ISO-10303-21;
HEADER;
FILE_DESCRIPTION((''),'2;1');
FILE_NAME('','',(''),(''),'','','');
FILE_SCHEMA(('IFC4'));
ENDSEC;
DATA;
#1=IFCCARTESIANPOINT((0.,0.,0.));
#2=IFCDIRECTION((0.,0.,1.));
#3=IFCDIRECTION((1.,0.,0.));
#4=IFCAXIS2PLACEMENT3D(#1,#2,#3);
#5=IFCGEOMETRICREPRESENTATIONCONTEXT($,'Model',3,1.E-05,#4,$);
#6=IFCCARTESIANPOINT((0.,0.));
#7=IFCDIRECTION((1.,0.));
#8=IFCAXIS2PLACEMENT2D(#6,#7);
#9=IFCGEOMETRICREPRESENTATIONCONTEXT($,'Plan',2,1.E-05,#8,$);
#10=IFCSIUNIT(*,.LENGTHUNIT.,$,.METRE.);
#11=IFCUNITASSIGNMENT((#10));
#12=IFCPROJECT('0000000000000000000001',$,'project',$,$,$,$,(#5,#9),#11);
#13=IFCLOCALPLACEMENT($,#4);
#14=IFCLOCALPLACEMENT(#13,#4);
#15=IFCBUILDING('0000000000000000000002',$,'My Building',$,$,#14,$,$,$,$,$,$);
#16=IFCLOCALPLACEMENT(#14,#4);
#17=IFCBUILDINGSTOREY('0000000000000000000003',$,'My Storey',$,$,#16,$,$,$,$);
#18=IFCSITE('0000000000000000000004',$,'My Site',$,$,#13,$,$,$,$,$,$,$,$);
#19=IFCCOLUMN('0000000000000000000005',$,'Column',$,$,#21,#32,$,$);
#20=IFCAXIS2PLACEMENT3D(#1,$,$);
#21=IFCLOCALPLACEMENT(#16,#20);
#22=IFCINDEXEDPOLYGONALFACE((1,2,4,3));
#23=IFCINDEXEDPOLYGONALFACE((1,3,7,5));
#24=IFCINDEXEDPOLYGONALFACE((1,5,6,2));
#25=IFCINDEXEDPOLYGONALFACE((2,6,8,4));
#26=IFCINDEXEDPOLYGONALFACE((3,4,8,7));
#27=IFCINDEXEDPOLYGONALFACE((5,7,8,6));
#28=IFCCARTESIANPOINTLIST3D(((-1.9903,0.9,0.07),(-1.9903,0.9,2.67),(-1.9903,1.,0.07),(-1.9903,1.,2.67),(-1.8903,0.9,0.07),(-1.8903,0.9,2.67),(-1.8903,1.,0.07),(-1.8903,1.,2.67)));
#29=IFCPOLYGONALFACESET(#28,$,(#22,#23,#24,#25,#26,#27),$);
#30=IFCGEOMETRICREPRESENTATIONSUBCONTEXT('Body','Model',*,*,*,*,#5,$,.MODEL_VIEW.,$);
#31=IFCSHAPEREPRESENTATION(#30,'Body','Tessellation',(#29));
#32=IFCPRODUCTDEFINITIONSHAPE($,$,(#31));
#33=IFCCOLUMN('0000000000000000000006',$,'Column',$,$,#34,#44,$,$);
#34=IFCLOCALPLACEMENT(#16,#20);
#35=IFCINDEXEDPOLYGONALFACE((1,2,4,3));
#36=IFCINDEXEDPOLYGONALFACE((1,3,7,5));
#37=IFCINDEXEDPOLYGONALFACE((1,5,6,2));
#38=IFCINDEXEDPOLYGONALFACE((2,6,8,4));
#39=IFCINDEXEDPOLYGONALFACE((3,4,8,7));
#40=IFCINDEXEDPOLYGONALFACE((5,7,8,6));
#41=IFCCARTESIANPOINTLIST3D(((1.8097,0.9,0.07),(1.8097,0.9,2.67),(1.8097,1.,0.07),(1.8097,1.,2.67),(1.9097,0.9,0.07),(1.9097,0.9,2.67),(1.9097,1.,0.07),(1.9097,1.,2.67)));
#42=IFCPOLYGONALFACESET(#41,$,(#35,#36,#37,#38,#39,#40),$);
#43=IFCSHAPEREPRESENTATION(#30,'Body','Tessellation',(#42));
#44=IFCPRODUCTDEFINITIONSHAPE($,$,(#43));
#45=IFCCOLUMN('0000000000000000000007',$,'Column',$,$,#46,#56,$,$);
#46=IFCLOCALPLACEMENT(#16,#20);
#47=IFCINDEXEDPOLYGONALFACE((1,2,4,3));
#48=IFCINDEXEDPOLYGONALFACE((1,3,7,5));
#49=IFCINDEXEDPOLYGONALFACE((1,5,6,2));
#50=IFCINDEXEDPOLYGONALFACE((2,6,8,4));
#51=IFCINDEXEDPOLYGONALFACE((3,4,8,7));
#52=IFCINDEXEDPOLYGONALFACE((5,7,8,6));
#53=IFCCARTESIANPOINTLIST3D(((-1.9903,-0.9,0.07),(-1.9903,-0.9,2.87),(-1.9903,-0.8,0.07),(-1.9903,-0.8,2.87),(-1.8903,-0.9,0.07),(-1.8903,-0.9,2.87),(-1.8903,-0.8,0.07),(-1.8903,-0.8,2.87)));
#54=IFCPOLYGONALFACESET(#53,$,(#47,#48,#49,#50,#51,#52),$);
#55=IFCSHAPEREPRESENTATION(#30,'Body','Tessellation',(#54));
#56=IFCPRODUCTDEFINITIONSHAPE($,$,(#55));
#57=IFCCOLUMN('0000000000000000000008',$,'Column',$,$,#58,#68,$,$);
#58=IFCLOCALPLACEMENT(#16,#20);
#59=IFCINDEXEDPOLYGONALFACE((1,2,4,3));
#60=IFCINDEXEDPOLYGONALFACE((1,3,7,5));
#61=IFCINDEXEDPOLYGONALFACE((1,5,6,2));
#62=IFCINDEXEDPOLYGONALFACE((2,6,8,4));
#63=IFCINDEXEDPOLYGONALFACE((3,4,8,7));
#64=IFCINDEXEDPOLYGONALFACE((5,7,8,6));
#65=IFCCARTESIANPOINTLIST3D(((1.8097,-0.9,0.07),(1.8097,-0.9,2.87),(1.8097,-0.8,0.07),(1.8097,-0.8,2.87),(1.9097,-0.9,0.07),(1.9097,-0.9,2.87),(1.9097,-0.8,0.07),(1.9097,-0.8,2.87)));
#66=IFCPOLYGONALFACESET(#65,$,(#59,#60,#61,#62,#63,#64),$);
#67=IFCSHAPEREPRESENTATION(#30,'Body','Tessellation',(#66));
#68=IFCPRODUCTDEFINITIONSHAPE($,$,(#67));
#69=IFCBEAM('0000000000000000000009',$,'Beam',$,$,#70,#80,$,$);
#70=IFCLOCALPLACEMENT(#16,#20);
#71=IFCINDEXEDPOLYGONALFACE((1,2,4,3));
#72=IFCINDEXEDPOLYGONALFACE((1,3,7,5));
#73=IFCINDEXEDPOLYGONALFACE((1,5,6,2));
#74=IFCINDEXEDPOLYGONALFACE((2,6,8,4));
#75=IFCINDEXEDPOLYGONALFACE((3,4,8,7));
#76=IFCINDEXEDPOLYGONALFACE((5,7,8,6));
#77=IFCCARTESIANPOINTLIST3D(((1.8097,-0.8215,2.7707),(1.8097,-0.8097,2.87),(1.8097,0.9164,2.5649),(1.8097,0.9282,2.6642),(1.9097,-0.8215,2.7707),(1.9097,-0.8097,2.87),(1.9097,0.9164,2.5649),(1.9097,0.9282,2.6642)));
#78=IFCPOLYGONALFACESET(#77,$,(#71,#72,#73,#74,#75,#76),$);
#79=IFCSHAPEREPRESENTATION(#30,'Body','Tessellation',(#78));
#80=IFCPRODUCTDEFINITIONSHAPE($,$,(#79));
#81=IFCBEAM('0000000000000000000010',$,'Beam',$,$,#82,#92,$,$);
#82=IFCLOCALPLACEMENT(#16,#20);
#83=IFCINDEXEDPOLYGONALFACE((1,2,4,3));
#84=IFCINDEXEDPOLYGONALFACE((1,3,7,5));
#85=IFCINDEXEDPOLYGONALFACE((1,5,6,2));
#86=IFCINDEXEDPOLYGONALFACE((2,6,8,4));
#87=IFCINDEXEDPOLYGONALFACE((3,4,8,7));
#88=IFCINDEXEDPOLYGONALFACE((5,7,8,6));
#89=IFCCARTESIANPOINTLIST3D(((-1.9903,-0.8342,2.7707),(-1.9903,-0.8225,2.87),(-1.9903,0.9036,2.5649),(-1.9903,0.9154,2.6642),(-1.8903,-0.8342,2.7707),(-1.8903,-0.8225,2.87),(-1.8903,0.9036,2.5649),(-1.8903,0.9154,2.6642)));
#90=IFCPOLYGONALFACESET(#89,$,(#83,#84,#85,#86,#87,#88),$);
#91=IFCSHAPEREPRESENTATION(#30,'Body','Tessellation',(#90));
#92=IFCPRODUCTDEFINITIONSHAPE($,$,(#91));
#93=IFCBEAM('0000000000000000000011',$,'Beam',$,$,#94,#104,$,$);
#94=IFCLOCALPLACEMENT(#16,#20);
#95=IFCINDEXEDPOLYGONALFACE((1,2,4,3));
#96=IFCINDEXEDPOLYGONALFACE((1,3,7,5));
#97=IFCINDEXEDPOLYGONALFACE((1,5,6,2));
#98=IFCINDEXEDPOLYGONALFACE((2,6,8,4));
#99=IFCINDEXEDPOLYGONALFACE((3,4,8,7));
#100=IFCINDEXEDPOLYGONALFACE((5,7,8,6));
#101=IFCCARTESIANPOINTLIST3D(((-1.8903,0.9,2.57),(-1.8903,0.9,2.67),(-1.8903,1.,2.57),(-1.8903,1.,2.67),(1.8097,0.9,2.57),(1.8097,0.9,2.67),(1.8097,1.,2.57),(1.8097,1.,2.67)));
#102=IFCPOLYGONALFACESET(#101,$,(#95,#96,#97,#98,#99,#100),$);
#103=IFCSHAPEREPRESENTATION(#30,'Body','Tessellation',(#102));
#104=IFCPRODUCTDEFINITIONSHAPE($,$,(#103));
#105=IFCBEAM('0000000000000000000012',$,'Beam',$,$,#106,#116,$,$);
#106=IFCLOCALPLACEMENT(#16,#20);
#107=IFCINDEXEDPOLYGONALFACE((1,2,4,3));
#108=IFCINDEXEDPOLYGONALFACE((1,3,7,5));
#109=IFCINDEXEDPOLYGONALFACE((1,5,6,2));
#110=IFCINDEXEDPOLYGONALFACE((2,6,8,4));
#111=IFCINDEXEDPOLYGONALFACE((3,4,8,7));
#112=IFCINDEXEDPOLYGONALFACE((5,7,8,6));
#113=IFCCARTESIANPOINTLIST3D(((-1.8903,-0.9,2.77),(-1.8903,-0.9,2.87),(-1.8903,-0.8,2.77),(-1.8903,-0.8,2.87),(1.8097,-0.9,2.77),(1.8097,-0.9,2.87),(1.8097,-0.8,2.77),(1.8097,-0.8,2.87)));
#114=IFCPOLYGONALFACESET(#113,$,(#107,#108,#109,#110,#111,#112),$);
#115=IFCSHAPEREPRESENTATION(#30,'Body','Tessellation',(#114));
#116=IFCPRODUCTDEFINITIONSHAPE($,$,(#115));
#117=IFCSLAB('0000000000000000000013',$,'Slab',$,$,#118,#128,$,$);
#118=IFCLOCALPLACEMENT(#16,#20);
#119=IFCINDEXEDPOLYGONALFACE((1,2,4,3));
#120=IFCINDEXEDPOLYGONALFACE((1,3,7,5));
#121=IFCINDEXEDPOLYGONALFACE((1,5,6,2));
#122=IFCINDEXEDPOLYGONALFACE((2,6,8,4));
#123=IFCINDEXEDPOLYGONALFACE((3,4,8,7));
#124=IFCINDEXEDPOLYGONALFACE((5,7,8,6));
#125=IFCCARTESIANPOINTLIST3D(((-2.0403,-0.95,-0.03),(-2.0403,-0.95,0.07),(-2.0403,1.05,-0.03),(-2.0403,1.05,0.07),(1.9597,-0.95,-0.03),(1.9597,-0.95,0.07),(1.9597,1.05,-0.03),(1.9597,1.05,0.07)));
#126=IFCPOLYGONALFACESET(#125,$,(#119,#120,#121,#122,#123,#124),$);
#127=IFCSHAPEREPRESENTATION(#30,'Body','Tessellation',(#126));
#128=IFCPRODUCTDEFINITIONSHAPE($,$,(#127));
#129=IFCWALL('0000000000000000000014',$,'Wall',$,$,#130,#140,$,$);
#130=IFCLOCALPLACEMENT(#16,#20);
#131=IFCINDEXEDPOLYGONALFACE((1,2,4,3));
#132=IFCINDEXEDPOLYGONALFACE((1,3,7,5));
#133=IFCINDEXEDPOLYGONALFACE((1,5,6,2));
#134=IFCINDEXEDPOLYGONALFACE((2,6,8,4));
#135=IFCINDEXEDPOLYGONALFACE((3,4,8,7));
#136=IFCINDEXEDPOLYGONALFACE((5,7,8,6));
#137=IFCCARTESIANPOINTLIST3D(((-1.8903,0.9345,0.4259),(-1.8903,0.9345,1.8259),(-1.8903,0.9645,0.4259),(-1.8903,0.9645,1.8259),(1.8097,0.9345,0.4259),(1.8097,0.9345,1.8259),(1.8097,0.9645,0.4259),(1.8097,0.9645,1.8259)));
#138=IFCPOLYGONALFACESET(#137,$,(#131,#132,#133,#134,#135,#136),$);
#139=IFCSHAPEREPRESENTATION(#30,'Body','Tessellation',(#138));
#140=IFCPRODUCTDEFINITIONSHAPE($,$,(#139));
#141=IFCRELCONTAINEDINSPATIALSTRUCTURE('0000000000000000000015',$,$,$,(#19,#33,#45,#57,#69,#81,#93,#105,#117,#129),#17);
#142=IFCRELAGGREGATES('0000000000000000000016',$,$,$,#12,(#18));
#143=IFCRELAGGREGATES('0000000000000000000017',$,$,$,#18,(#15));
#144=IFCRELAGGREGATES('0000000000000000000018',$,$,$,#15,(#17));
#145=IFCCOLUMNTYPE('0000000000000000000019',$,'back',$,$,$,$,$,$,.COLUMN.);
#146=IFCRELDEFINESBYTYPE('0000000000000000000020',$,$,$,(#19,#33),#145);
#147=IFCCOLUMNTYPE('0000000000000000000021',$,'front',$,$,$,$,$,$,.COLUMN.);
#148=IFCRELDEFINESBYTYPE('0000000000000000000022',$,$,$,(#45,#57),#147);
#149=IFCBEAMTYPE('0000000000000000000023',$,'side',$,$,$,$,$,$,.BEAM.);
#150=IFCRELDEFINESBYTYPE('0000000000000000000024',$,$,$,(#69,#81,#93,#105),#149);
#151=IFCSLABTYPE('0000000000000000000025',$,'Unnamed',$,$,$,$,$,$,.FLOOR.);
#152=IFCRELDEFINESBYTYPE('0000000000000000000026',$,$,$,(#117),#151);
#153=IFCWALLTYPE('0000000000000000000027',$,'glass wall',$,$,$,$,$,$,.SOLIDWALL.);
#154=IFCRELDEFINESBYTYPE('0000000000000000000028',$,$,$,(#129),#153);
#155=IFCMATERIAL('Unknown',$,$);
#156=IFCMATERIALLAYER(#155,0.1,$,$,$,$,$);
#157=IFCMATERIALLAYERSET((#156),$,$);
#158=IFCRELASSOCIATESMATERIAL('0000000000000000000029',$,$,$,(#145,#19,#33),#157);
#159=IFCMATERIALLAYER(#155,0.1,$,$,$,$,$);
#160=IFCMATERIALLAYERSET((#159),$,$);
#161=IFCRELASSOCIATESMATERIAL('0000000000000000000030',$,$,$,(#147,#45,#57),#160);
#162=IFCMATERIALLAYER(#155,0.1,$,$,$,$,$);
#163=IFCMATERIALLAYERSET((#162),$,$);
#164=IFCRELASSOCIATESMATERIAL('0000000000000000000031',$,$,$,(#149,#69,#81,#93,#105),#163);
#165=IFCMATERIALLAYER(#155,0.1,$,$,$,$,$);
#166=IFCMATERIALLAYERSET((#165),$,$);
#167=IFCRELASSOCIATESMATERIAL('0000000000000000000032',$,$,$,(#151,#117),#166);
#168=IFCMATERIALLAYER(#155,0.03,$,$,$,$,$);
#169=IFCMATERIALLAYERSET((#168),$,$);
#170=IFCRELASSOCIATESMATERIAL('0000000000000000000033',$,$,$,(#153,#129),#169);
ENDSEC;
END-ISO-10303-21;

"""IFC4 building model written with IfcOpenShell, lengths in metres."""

from ifc_helpers import new_model, si_unit, frame, origin_with_axes, origin_2d_with_axis, place, context, subcontext, project, spatial, line, indexed_curve, outline, extrude, material, layer, layer_set, layer_usage, type_object, element, save


model = new_model("IFC4")

# Units and contexts
model_context = context("Model", 3, precision=1e-05, world=origin_with_axes())
plan_context = context("Plan", 2, precision=1e-05, world=origin_2d_with_axis())
body_context = subcontext(model_context, "Body", "Model", "MODEL_VIEW")
ifc_project = project(units=[si_unit("LENGTHUNIT", "METRE")], contexts=[model_context, plan_context])

# Site, building, storey
site_placement = place(None, origin_with_axes())
site = spatial("IfcSite", under=ifc_project, at=site_placement, Name="My Site")
building_placement = place(site_placement, origin_with_axes())
building = spatial("IfcBuilding", under=site, at=building_placement, Name="My Building")
storey_placement = place(building_placement, origin_with_axes())
storey = spatial("IfcBuildingStorey", under=building, at=storey_placement, Name="My Storey")

# Columns
ifc_material = material(Name="Unknown")
ifc_layer_1 = layer(ifc_material, 0.1)
ifc_layer_set_1 = layer_set([ifc_layer_1])
ifc_layer_usage_1 = layer_usage(ifc_layer_set_1, "AXIS2", "POSITIVE", 0.0)
column_type_1 = type_object("IfcColumnType", Name="back", PredefinedType="COLUMN", material=ifc_layer_set_1)
column_1_placement = place(storey_placement, frame((-1.9903, 1.0, 0.07), z_axis=(0.0, 0.0, 1.0), x_axis=(0.0, -1.0, 0.0)))
element("IfcColumn", 1, at=column_1_placement, inside=storey, type_object=column_type_1, material=ifc_layer_usage_1, Name="Column", context=body_context, shape_type="SweptSolid", body=[
    extrude(outline(indexed_curve([(0.0, 0.0), (0.0, 0.1), (0.1, 0.1), (0.1, 0.0)], segments=[line(1, 2, 3, 4, 1)])), origin_with_axes(), (0.0, 0.0, 1.0), 2.6),
])
ifc_layer_usage_2 = layer_usage(ifc_layer_set_1, "AXIS2", "POSITIVE", 0.0)
column_2_placement = place(storey_placement, frame((1.8097, 0.9, 0.07), z_axis=(0.0, 0.0, 1.0), x_axis=(1.0, 0.0, 0.0)))
element("IfcColumn", 2, at=column_2_placement, inside=storey, type_object=column_type_1, material=ifc_layer_usage_2, Name="Column", context=body_context, shape_type="SweptSolid", body=[
    extrude(outline(indexed_curve([(0.0, 0.0), (0.0, 0.1), (0.1, 0.1), (0.1, 0.0)], segments=[line(1, 2, 3, 4, 1)])), origin_with_axes(), (0.0, 0.0, 1.0), 2.6),
])
ifc_layer_2 = layer(ifc_material, 0.1)
ifc_layer_set_2 = layer_set([ifc_layer_2])
ifc_layer_usage_3 = layer_usage(ifc_layer_set_2, "AXIS2", "POSITIVE", 0.0)
column_type_2 = type_object("IfcColumnType", Name="front", PredefinedType="COLUMN", material=ifc_layer_set_2)
column_3_placement = place(storey_placement, frame((-1.9903, -0.8, 0.07), z_axis=(0.0, 0.0, 1.0), x_axis=(0.0, -1.0, 0.0)))
element("IfcColumn", 3, at=column_3_placement, inside=storey, type_object=column_type_2, material=ifc_layer_usage_3, Name="Column", context=body_context, shape_type="SweptSolid", body=[
    extrude(outline(indexed_curve([(0.0, 0.0), (0.0, 0.1), (0.1, 0.1), (0.1, 0.0)], segments=[line(1, 2, 3, 4, 1)])), origin_with_axes(), (0.0, 0.0, 1.0), 2.8),
])
ifc_layer_usage_4 = layer_usage(ifc_layer_set_2, "AXIS2", "POSITIVE", 0.0)
column_4_placement = place(storey_placement, frame((1.8097, -0.8, 0.07), z_axis=(0.0, 0.0, 1.0), x_axis=(0.0, -1.0, 0.0)))
element("IfcColumn", 4, at=column_4_placement, inside=storey, type_object=column_type_2, material=ifc_layer_usage_4, Name="Column", context=body_context, shape_type="SweptSolid", body=[
    extrude(outline(indexed_curve([(0.0, 0.0), (0.0, 0.1), (0.1, 0.1), (0.1, 0.0)], segments=[line(1, 2, 3, 4, 1)])), origin_with_axes(), (0.0, 0.0, 1.0), 2.8),
])

# Beams
ifc_layer_3 = layer(ifc_material, 0.1)
ifc_layer_set_3 = layer_set([ifc_layer_3])
ifc_layer_usage_5 = layer_usage(ifc_layer_set_3, "AXIS3", "POSITIVE", -0.1)
beam_type = type_object("IfcBeamType", Name="side", PredefinedType="BEAM", material=ifc_layer_set_3)
beam_1_placement = place(storey_placement, frame((1.8097, -0.8097, 2.87), z_axis=(0.0, 0.117589, 0.993062), x_axis=(1.0, 0.0, 0.0)))
element("IfcBeam", 5, at=beam_1_placement, inside=storey, type_object=beam_type, material=ifc_layer_usage_5, Name="Beam", context=body_context, shape_type="SweptSolid", body=[
    extrude(outline(indexed_curve([(0.0, 0.0), (0.0, 1.75), (0.1, 1.75), (0.1, 0.0), (0.0, 0.0)])), frame((0.0, 0.0, -0.1), z_axis=(0.0, 0.0, 1.0), x_axis=(1.0, 0.0, 0.0)), (0.0, 0.0, 1.0), 0.1),
])
ifc_layer_usage_6 = layer_usage(ifc_layer_set_3, "AXIS3", "POSITIVE", -0.1)
beam_2_placement = place(storey_placement, frame((-1.9903, -0.8225, 2.87), z_axis=(0.0, 0.117589, 0.993062), x_axis=(1.0, 0.0, 0.0)))
element("IfcBeam", 6, at=beam_2_placement, inside=storey, type_object=beam_type, material=ifc_layer_usage_6, Name="Beam", context=body_context, shape_type="SweptSolid", body=[
    extrude(outline(indexed_curve([(0.0, 0.0), (0.0, 1.75), (0.1, 1.75), (0.1, 0.0), (0.0, 0.0)])), frame((0.0, 0.0, -0.1), z_axis=(0.0, 0.0, 1.0), x_axis=(1.0, 0.0, 0.0)), (0.0, 0.0, 1.0), 0.1),
])
ifc_layer_usage_7 = layer_usage(ifc_layer_set_3, "AXIS3", "POSITIVE", -0.1)
beam_3_placement = place(storey_placement, frame((1.8097, 0.9, 2.67), z_axis=(0.0, 0.0, 1.0), x_axis=(1.0, 0.0, 0.0)))
element("IfcBeam", 7, at=beam_3_placement, inside=storey, type_object=beam_type, material=ifc_layer_usage_7, Name="Beam", context=body_context, shape_type="SweptSolid", body=[
    extrude(outline(indexed_curve([(0.0, 0.0), (-3.7, 0.0), (-3.7, 0.1), (0.0, 0.1), (0.0, 0.0)])), frame((0.0, 0.0, -0.1), z_axis=(0.0, 0.0, 1.0), x_axis=(1.0, 0.0, 0.0)), (0.0, 0.0, 1.0), 0.1),
])
ifc_layer_usage_8 = layer_usage(ifc_layer_set_3, "AXIS3", "POSITIVE", -0.1)
beam_4_placement = place(storey_placement, frame((1.8097, -0.9, 2.87), z_axis=(0.0, 0.0, 1.0), x_axis=(1.0, 0.0, 0.0)))
element("IfcBeam", 8, at=beam_4_placement, inside=storey, type_object=beam_type, material=ifc_layer_usage_8, Name="Beam", context=body_context, shape_type="SweptSolid", body=[
    extrude(outline(indexed_curve([(0.0, 0.0), (-3.7, 0.0), (-3.7, 0.1), (0.0, 0.1), (0.0, 0.0)])), frame((0.0, 0.0, -0.1), z_axis=(0.0, 0.0, 1.0), x_axis=(1.0, 0.0, 0.0)), (0.0, 0.0, 1.0), 0.1),
])

# Slab
ifc_layer_4 = layer(ifc_material, 0.1)
ifc_layer_set_4 = layer_set([ifc_layer_4])
ifc_layer_usage_9 = layer_usage(ifc_layer_set_4, "AXIS3", "POSITIVE", -0.1)
slab_type = type_object("IfcSlabType", Name="Unnamed", PredefinedType="FLOOR", material=ifc_layer_set_4)
slab_placement = place(storey_placement, frame((-2.0403, 1.05, 0.07), z_axis=(0.0, 0.0, 1.0), x_axis=(1.0, 0.0, 0.0)))
element("IfcSlab", 9, at=slab_placement, inside=storey, type_object=slab_type, material=ifc_layer_usage_9, Name="Slab", context=body_context, shape_type="SweptSolid", body=[
    extrude(outline(indexed_curve([(0.0, 0.0), (4.0, 0.0), (4.0, -2.0), (0.0, -2.0), (0.0, 0.0)])), frame((0.0, 0.0, -0.1), z_axis=(0.0, 0.0, 1.0), x_axis=(1.0, 0.0, 0.0)), (0.0, 0.0, 1.0), 0.1),
])

# Wall
ifc_layer_5 = layer(ifc_material, 0.03)
ifc_layer_set_5 = layer_set([ifc_layer_5])
ifc_layer_usage_10 = layer_usage(ifc_layer_set_5, "AXIS2", "POSITIVE", 0.0)
wall_type = type_object("IfcWallType", Name="glass wall", PredefinedType="SOLIDWALL", material=ifc_layer_set_5)
wall_placement = place(storey_placement, frame((-1.8903, 0.9345, 0.4259), z_axis=(0.0, 0.0, 1.0), x_axis=(1.0, 0.0, 0.0)))
element("IfcWall", 10, at=wall_placement, inside=storey, type_object=wall_type, material=ifc_layer_usage_10, Name="Wall", context=body_context, shape_type="SweptSolid", body=[
    extrude(outline(indexed_curve([(0.0, 0.0), (0.0, 0.03), (3.7, 0.03), (3.7, 0.0)], segments=[line(1, 2, 3, 4, 1)])), origin_with_axes(), (0.0, 0.0, 1.0), 1.4),
])

save(model, "model.ifc")
